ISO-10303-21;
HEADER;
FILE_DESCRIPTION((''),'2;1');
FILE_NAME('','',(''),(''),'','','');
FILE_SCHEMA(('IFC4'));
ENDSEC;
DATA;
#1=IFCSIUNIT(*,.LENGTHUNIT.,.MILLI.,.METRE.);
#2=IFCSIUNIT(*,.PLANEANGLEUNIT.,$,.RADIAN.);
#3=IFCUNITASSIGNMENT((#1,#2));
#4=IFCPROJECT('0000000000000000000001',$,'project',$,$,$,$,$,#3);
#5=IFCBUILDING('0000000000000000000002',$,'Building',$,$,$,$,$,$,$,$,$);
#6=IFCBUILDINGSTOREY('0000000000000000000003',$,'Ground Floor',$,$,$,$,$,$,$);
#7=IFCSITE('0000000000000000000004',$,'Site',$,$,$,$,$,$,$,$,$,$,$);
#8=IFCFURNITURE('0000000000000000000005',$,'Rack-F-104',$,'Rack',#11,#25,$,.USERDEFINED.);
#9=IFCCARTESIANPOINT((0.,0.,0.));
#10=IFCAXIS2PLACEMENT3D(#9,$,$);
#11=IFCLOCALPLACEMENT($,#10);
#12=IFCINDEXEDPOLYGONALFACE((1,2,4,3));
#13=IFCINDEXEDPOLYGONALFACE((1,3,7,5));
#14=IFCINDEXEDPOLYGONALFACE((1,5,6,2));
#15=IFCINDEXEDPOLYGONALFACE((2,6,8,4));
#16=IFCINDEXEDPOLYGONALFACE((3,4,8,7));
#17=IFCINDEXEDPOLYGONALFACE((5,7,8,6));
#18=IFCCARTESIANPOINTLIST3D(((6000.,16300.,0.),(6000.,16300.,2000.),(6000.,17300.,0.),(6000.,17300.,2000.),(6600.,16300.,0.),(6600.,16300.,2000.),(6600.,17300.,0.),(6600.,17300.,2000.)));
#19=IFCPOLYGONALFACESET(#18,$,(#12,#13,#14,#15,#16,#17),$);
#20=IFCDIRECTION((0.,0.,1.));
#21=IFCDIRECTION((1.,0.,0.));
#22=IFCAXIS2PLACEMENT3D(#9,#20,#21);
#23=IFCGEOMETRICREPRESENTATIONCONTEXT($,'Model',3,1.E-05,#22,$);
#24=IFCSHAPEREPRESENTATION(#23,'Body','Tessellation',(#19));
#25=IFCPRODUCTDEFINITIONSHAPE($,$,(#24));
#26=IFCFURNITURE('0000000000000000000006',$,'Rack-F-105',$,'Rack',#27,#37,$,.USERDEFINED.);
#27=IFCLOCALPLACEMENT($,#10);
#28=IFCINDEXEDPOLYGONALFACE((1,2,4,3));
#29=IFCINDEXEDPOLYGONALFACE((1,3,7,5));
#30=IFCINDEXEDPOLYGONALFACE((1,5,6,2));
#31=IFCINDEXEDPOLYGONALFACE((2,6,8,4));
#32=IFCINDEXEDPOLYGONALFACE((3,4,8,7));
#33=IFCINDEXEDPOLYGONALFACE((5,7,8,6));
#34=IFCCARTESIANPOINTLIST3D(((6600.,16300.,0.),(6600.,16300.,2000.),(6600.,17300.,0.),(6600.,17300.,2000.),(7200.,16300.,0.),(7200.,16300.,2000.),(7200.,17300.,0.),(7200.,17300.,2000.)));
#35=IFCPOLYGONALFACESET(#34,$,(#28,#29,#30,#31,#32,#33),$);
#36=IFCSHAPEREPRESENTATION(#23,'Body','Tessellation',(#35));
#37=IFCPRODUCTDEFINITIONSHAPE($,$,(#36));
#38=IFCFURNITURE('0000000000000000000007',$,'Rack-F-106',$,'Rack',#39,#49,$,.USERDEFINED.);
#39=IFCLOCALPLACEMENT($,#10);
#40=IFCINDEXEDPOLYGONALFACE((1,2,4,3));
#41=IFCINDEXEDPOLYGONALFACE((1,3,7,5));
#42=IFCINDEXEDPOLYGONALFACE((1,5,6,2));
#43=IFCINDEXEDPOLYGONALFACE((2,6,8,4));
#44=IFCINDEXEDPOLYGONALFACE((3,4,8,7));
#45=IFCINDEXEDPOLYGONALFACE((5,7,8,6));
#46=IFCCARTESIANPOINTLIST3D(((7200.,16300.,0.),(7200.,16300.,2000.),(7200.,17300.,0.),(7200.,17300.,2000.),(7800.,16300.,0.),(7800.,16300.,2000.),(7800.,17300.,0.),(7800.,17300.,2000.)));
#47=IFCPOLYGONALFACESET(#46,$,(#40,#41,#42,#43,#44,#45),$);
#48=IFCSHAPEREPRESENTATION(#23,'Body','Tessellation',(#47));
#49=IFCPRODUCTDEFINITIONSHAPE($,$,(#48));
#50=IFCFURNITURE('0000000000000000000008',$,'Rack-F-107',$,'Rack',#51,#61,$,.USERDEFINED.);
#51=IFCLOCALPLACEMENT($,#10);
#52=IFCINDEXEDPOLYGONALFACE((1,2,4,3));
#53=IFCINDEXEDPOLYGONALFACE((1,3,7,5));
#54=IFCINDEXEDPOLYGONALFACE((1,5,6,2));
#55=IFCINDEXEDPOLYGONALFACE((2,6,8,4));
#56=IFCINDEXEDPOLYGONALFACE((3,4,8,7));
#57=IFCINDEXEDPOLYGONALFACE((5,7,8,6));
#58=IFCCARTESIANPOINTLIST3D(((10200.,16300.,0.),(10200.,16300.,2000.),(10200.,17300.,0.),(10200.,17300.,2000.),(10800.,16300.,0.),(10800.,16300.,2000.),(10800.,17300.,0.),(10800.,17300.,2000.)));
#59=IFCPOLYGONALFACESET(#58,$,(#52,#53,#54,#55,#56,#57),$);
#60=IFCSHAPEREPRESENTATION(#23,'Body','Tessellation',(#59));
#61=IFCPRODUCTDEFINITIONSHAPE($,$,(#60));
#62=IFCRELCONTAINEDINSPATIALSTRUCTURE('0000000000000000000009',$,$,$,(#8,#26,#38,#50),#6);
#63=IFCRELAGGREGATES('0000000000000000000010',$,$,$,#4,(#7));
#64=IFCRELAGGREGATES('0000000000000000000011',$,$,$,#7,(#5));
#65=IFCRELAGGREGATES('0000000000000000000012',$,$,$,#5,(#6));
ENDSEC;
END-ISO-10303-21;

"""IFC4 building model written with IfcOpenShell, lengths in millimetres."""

from ifc_helpers import new_model, si_unit, frame, origin_with_axes, place, context, project, spatial, rectangle, extrude, element, save


model = new_model("IFC4")

# Units and contexts
model_context = context("Model", 3, precision=1e-05, world=origin_with_axes())
ifc_project = project(units=[si_unit("LENGTHUNIT", "METRE", prefix="MILLI"), si_unit("PLANEANGLEUNIT", "RADIAN")])

# Site, building, storey
site = spatial("IfcSite", under=ifc_project, Name="Site")
building = spatial("IfcBuilding", under=site, Name="Building")
storey = spatial("IfcBuildingStorey", under=building, Name="Ground Floor")

# Furniture
furniture_1_placement = place(None, origin_with_axes())
element("IfcFurniture", 1, at=furniture_1_placement, inside=storey, Name="Rack-F-104", ObjectType="Rack", PredefinedType="USERDEFINED", context=model_context, shape_type="SweptSolid", body=[
    extrude(rectangle(XDim=600.0, YDim=1000.0), frame((6300.0, 16800.0, 0.0), z_axis=(0.0, 0.0, 1.0), x_axis=(1.0, 0.0, 0.0)), (0.0, 0.0, 1.0), 2000.0),
])
furniture_2_placement = place(None, origin_with_axes())
element("IfcFurniture", 2, at=furniture_2_placement, inside=storey, Name="Rack-F-105", ObjectType="Rack", PredefinedType="USERDEFINED", context=model_context, shape_type="SweptSolid", body=[
    extrude(rectangle(XDim=600.0, YDim=1000.0), frame((6900.0, 16800.0, 0.0), z_axis=(0.0, 0.0, 1.0), x_axis=(1.0, 0.0, 0.0)), (0.0, 0.0, 1.0), 2000.0),
])
furniture_3_placement = place(None, origin_with_axes())
element("IfcFurniture", 3, at=furniture_3_placement, inside=storey, Name="Rack-F-106", ObjectType="Rack", PredefinedType="USERDEFINED", context=model_context, shape_type="SweptSolid", body=[
    extrude(rectangle(XDim=600.0, YDim=1000.0), frame((7500.0, 16800.0, 0.0), z_axis=(0.0, 0.0, 1.0), x_axis=(1.0, 0.0, 0.0)), (0.0, 0.0, 1.0), 2000.0),
])
furniture_4_placement = place(None, origin_with_axes())
element("IfcFurniture", 4, at=furniture_4_placement, inside=storey, Name="Rack-F-107", ObjectType="Rack", PredefinedType="USERDEFINED", context=model_context, shape_type="SweptSolid", body=[
    extrude(rectangle(XDim=600.0, YDim=1000.0), frame((10500.0, 16800.0, 0.0), z_axis=(0.0, 0.0, 1.0), x_axis=(1.0, 0.0, 0.0)), (0.0, 0.0, 1.0), 2000.0),
])

save(model, "model.ifc")
